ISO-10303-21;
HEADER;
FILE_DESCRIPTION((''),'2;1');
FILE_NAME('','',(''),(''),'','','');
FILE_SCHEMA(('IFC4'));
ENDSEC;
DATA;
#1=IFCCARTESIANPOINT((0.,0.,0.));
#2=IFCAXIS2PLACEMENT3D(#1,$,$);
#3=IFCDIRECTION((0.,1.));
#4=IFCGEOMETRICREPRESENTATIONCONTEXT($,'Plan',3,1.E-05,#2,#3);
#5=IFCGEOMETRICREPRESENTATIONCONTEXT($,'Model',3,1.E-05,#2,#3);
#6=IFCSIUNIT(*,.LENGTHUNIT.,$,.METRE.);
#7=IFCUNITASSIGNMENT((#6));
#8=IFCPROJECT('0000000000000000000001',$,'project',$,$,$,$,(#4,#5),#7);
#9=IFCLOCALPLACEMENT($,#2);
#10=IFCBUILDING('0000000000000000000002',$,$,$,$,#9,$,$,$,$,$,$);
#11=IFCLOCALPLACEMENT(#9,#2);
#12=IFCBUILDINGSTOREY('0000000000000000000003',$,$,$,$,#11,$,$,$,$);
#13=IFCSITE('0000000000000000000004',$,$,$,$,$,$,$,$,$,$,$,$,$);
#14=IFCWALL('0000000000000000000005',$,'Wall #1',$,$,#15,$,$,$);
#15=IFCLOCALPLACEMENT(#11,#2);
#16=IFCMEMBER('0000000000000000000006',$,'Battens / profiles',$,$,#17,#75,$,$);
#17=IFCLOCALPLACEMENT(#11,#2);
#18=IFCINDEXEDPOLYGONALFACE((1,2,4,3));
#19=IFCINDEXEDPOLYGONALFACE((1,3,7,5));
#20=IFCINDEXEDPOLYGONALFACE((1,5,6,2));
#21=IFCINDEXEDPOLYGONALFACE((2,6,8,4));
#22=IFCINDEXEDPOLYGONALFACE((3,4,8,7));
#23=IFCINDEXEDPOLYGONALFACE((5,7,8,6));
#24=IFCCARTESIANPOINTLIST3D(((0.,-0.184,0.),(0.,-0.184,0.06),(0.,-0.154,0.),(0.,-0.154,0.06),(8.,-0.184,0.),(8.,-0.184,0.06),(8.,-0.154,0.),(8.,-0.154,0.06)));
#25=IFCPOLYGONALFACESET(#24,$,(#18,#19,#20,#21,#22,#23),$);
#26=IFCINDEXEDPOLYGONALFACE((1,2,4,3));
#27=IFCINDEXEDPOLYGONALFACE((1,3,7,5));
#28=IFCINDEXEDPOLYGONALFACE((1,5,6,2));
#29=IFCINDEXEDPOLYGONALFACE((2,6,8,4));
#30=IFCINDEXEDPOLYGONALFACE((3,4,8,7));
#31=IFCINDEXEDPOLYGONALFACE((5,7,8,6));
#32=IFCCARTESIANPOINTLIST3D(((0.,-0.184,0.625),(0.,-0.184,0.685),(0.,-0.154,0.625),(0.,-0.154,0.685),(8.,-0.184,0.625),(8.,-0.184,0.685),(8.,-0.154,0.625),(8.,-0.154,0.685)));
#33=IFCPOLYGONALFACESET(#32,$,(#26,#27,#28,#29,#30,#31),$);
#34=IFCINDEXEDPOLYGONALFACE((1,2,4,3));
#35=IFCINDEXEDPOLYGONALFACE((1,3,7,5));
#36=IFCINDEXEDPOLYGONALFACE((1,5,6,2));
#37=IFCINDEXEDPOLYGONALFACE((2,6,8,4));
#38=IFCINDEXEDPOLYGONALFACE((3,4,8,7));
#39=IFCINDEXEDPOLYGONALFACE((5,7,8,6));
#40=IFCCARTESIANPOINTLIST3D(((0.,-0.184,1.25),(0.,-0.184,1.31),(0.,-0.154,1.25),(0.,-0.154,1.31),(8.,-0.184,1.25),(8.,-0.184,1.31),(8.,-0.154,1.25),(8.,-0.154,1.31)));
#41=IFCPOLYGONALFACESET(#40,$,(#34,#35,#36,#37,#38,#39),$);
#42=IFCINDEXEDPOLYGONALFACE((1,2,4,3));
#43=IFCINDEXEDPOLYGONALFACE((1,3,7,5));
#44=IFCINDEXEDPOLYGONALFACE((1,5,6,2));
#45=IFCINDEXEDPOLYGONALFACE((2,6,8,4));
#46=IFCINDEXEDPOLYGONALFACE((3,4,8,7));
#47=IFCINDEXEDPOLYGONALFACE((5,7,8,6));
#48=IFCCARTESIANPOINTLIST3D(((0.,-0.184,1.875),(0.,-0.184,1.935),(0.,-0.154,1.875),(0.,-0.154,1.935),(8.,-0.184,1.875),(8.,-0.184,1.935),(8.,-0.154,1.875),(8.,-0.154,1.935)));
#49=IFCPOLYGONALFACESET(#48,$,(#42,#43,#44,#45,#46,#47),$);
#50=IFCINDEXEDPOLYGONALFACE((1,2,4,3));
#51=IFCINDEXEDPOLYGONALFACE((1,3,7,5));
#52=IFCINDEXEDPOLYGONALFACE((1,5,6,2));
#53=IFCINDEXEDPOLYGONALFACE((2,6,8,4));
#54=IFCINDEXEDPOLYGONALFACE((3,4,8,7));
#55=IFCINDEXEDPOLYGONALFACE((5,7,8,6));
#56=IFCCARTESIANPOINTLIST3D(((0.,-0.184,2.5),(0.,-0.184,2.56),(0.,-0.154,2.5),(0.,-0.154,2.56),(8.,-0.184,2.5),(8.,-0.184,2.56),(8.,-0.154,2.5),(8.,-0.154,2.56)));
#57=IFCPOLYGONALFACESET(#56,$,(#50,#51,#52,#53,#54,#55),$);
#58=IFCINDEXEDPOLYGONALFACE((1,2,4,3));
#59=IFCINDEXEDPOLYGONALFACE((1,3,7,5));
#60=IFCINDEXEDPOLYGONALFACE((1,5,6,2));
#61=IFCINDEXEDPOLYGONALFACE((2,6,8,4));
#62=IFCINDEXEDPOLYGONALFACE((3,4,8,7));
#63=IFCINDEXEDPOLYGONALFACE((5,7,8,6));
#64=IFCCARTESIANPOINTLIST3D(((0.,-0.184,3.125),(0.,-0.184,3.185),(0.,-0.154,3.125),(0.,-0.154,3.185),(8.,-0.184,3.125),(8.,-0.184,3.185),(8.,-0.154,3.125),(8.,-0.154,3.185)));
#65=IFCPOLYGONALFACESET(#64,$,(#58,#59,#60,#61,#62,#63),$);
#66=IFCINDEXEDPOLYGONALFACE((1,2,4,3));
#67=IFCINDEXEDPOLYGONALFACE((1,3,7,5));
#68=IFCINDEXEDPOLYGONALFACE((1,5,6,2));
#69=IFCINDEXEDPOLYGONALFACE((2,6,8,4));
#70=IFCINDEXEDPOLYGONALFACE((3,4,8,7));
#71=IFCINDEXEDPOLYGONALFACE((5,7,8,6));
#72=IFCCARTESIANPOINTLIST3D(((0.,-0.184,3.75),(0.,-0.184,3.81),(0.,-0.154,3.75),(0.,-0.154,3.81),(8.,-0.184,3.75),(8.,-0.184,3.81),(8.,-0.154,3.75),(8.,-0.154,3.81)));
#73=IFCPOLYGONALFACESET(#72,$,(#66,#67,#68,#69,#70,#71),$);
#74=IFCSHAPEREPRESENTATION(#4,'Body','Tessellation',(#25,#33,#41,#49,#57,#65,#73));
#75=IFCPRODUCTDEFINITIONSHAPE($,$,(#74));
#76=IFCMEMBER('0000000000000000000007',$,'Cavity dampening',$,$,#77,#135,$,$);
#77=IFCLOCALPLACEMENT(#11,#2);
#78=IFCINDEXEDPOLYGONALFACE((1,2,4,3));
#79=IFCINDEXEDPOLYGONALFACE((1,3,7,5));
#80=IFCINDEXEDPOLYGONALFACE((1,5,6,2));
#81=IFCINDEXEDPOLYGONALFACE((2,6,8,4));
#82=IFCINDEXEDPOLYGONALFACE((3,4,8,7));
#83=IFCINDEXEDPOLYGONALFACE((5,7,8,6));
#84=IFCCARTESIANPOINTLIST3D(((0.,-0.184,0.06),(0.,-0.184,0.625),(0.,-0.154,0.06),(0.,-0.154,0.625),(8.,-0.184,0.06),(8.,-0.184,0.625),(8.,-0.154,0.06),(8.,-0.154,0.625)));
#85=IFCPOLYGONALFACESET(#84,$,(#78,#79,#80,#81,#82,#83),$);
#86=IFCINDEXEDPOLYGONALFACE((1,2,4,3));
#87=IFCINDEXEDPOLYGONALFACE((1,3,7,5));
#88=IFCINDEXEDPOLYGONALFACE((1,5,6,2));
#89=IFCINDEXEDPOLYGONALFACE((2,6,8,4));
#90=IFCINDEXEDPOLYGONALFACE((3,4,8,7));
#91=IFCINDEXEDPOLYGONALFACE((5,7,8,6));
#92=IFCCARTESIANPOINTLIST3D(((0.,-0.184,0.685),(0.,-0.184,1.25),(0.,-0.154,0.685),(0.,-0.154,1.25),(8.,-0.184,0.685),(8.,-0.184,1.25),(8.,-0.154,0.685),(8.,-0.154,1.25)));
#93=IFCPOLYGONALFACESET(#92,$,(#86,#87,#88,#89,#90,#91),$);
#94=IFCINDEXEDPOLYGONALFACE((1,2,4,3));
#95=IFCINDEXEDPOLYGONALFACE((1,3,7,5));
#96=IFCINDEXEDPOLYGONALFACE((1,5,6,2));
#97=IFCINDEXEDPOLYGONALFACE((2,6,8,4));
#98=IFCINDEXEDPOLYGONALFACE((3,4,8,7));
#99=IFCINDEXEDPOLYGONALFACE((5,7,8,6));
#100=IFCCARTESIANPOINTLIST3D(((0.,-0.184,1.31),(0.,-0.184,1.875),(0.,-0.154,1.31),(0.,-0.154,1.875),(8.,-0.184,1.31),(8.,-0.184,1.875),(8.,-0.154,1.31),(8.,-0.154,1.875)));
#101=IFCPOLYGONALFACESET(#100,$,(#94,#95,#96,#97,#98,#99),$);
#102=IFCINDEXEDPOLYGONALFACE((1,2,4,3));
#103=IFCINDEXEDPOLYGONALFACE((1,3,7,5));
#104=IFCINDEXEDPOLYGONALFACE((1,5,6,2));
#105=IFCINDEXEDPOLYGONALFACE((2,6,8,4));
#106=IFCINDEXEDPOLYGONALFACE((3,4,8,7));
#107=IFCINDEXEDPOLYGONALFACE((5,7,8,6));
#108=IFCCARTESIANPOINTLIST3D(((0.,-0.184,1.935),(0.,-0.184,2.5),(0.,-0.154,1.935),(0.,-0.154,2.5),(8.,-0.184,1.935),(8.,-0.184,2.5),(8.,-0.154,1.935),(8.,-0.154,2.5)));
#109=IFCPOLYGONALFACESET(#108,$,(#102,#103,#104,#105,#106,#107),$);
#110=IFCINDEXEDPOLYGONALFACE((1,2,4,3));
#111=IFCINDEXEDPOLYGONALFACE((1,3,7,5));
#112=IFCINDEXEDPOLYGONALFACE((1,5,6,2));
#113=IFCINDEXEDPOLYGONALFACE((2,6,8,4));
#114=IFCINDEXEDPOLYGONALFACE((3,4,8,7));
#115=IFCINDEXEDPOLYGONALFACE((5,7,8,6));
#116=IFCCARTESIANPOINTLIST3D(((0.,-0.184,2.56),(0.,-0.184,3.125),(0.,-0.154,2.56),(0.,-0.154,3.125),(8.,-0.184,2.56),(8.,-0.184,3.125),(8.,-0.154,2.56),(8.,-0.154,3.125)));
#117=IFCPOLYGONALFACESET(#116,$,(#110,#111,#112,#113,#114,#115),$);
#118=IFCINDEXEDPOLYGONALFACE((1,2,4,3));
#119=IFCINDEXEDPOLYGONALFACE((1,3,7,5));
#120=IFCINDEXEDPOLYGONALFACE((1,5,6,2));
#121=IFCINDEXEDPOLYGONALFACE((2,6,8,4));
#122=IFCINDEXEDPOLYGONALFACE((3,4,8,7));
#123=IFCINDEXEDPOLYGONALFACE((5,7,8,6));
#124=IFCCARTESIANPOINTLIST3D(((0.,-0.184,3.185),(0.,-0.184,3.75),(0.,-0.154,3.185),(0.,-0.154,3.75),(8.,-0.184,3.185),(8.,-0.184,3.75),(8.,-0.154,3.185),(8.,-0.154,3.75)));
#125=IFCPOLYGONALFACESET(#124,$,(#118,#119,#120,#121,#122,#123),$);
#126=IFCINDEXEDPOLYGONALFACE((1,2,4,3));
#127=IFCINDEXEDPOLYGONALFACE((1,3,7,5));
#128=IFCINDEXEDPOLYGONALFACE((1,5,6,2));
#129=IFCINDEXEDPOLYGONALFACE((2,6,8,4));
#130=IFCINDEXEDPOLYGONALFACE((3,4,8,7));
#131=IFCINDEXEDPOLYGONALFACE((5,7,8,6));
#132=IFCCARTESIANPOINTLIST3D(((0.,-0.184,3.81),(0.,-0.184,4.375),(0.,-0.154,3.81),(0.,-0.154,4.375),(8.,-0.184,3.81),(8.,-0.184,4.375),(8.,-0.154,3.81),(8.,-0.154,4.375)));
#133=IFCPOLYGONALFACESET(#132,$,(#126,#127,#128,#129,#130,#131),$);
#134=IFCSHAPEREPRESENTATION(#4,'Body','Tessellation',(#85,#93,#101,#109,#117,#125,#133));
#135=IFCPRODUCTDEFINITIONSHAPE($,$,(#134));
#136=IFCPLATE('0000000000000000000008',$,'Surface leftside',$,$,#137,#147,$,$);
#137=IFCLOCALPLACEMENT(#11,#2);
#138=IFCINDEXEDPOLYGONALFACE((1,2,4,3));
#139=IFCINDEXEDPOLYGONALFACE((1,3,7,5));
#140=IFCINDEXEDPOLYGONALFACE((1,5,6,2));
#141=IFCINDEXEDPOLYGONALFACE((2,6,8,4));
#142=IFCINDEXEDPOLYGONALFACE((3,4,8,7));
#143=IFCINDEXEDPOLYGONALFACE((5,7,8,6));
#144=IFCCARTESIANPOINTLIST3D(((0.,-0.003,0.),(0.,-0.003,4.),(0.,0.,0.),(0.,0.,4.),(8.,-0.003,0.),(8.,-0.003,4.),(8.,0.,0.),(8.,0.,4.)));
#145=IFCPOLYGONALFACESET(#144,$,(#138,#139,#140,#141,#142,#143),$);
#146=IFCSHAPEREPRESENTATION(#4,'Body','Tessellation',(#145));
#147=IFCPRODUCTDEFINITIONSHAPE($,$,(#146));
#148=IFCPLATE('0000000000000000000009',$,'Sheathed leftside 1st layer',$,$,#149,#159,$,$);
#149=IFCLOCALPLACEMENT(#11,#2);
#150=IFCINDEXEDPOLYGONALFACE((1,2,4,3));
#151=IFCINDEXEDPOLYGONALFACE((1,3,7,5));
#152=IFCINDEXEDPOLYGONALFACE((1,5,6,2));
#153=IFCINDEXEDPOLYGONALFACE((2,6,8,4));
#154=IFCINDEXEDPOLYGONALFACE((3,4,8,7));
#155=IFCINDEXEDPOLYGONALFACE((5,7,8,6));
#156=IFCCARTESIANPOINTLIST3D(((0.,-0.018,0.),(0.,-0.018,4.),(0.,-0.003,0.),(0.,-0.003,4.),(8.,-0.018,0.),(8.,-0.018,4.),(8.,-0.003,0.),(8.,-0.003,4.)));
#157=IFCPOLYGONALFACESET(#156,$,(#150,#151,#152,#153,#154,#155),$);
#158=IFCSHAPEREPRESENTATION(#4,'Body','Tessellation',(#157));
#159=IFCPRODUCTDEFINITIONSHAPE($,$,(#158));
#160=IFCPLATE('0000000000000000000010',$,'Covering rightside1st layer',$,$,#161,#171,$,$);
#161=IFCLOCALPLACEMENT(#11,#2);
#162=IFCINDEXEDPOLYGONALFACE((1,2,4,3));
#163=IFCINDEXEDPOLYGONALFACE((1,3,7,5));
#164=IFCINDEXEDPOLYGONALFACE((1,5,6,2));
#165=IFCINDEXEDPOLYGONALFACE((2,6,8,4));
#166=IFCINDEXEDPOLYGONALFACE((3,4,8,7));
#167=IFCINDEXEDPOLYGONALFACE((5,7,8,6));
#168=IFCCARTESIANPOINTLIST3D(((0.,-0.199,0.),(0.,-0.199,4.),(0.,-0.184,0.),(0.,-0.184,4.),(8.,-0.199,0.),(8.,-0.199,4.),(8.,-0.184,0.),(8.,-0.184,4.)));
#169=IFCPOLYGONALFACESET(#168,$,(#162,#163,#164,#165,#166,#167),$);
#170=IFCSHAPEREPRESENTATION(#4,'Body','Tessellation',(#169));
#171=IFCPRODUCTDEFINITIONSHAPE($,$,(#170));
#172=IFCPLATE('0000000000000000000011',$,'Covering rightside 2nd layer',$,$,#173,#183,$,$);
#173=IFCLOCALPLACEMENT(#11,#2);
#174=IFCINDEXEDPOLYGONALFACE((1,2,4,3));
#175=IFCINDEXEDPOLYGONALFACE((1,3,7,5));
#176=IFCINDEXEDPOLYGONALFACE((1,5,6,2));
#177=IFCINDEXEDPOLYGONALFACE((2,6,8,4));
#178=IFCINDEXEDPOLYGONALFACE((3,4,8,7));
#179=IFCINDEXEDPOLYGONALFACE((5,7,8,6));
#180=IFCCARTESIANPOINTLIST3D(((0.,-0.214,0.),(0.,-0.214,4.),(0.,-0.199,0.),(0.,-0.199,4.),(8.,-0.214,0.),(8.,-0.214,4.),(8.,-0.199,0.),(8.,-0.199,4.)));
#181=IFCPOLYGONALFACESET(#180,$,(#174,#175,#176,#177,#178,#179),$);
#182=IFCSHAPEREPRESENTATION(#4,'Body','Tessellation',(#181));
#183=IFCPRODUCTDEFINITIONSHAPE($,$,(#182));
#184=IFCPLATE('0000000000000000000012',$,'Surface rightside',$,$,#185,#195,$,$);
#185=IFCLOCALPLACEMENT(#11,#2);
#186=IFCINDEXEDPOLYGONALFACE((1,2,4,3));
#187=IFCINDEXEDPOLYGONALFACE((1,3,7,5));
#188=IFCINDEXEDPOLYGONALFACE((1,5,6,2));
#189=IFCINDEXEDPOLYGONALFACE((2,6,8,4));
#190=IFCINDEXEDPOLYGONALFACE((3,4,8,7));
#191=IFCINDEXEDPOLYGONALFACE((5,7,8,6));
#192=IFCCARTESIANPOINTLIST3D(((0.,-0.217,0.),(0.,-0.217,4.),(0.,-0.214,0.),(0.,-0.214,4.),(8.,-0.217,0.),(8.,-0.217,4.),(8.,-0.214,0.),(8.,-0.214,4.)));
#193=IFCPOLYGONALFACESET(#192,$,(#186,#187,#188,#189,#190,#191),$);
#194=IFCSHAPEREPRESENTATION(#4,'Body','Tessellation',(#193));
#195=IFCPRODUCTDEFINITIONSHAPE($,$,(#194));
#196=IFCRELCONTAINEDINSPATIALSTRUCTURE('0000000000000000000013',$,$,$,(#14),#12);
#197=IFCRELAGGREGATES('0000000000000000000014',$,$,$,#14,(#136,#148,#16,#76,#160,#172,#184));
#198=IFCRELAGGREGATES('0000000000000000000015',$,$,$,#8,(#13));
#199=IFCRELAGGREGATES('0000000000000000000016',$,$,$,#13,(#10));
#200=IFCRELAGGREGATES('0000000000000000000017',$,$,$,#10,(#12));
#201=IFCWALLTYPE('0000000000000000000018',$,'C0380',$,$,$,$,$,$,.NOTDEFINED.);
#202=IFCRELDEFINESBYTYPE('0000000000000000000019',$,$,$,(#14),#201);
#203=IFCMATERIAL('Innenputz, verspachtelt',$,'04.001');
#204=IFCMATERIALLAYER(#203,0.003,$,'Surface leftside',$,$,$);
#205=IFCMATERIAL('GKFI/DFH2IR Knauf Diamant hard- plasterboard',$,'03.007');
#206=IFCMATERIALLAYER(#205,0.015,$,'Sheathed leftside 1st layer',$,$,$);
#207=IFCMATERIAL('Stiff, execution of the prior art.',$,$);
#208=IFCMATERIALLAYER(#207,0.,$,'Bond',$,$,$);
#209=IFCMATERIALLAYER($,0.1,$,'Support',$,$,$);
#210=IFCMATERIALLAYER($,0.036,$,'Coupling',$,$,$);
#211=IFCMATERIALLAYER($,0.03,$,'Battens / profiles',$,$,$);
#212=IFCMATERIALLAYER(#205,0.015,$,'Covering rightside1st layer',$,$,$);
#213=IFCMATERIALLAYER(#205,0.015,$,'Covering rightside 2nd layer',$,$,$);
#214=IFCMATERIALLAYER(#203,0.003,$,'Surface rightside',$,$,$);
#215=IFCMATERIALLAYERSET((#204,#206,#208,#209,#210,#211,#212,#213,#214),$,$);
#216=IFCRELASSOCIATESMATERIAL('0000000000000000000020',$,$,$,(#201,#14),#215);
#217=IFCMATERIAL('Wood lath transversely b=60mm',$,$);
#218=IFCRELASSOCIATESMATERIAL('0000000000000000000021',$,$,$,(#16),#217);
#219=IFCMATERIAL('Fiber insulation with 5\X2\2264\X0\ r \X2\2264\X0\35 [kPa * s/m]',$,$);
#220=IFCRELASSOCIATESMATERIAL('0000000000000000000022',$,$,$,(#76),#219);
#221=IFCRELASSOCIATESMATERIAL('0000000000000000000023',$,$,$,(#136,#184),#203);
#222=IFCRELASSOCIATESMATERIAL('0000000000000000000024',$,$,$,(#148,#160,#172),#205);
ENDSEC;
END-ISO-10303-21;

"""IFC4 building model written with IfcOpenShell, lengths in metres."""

from ifc_helpers import new_model, si_unit, direction, frame, frame_2d, origin, origin_with_axes, place, context, project, spatial, rectangle, extrude, material, layer, layer_set, type_object, element, aggregate, save


model = new_model("IFC4")

# Units and contexts
plan_context = context("Plan", 3, precision=1e-05, world=origin(), true_north=direction((0.0, 1.0)))
model_context = context("Model", 3, precision=1e-05, world=origin(), true_north=direction((0.0, 1.0)))
ifc_project = project(units=[si_unit("LENGTHUNIT", "METRE")], contexts=[plan_context, model_context])

# Site, building, storey
site = spatial("IfcSite", under=ifc_project)
building_placement = place(None, origin())
building = spatial("IfcBuilding", under=site, at=building_placement)
storey_placement = place(building_placement, origin())
storey = spatial("IfcBuildingStorey", under=building, at=storey_placement)

# Wall, members, plates
ifc_material_1 = material(Name="Innenputz, verspachtelt", Category="04.001")
ifc_layer_1 = layer(ifc_material_1, 0.003, Name="Surface leftside")
ifc_material_2 = material(Name="GKFI/DFH2IR Knauf Diamant hard- plasterboard", Category="03.007")
ifc_layer_2 = layer(ifc_material_2, 0.015, Name="Sheathed leftside 1st layer")
ifc_material_3 = material(Name="Stiff, execution of the prior art.")
ifc_layer_3 = layer(ifc_material_3, 0.0, Name="Bond")
ifc_layer_4 = layer(None, 0.1, Name="Support")
ifc_layer_5 = layer(None, 0.036, Name="Coupling")
ifc_layer_6 = layer(None, 0.03, Name="Battens / profiles")
ifc_layer_7 = layer(ifc_material_2, 0.015, Name="Covering rightside1st layer")
ifc_layer_8 = layer(ifc_material_2, 0.015, Name="Covering rightside 2nd layer")
ifc_layer_9 = layer(ifc_material_1, 0.003, Name="Surface rightside")
ifc_layer_set = layer_set([ifc_layer_1, ifc_layer_2, ifc_layer_3, ifc_layer_4, ifc_layer_5, ifc_layer_6, ifc_layer_7, ifc_layer_8, ifc_layer_9])
wall_type = type_object("IfcWallType", Name="C0380", PredefinedType="NOTDEFINED", material=ifc_layer_set)
wall_placement = place(None, frame((0.0, 0.0, 0.0), z_axis=(0.0, -1.0, 0.0), x_axis=(1.0, 0.0, 0.0)))
wall = element("IfcWall", 1, at=wall_placement, inside=storey, type_object=wall_type, material=ifc_layer_set, Name="Wall #1")
ifc_material_4 = material(Name="Wood lath transversely b=60mm")
member_1_placement = place(wall_placement, origin())
member_1 = element("IfcMember", 2, at=member_1_placement, material=ifc_material_4, Name="Battens / profiles", context=plan_context, shape_type="SweptSolid", body=[
    extrude(rectangle(XDim=0.06, YDim=0.03, at=frame_2d((0.03, 0.015), x_axis=(1.0, 0.0))), frame((0.0, 0.0, 0.154), z_axis=(1.0, 0.0, 0.0), x_axis=(0.0, 1.0, 0.0)), (0.0, 0.0, 1.0), 8.0),
    extrude(rectangle(XDim=0.06, YDim=0.03, at=frame_2d((0.03, 0.015), x_axis=(1.0, 0.0))), frame((0.0, 0.625, 0.154), z_axis=(1.0, 0.0, 0.0), x_axis=(0.0, 1.0, 0.0)), (0.0, 0.0, 1.0), 8.0),
    extrude(rectangle(XDim=0.06, YDim=0.03, at=frame_2d((0.03, 0.015), x_axis=(1.0, 0.0))), frame((0.0, 1.25, 0.154), z_axis=(1.0, 0.0, 0.0), x_axis=(0.0, 1.0, 0.0)), (0.0, 0.0, 1.0), 8.0),
    extrude(rectangle(XDim=0.06, YDim=0.03, at=frame_2d((0.03, 0.015), x_axis=(1.0, 0.0))), frame((0.0, 1.875, 0.154), z_axis=(1.0, 0.0, 0.0), x_axis=(0.0, 1.0, 0.0)), (0.0, 0.0, 1.0), 8.0),
    extrude(rectangle(XDim=0.06, YDim=0.03, at=frame_2d((0.03, 0.015), x_axis=(1.0, 0.0))), frame((0.0, 2.5, 0.154), z_axis=(1.0, 0.0, 0.0), x_axis=(0.0, 1.0, 0.0)), (0.0, 0.0, 1.0), 8.0),
    extrude(rectangle(XDim=0.06, YDim=0.03, at=frame_2d((0.03, 0.015), x_axis=(1.0, 0.0))), frame((0.0, 3.125, 0.154), z_axis=(1.0, 0.0, 0.0), x_axis=(0.0, 1.0, 0.0)), (0.0, 0.0, 1.0), 8.0),
    extrude(rectangle(XDim=0.06, YDim=0.03, at=frame_2d((0.03, 0.015), x_axis=(1.0, 0.0))), frame((0.0, 3.75, 0.154), z_axis=(1.0, 0.0, 0.0), x_axis=(0.0, 1.0, 0.0)), (0.0, 0.0, 1.0), 8.0),
])
ifc_material_5 = material(Name="Fiber insulation with 5≤ r ≤35 [kPa * s/m]")
member_2_placement = place(wall_placement, origin())
member_2 = element("IfcMember", 3, at=member_2_placement, material=ifc_material_5, Name="Cavity dampening", context=plan_context, shape_type="SweptSolid", body=[
    extrude(rectangle(XDim=0.565, YDim=0.03, at=frame_2d((0.2825, 0.015), x_axis=(1.0, 0.0))), frame((0.0, 0.06, 0.154), z_axis=(1.0, 0.0, 0.0), x_axis=(0.0, 1.0, 0.0)), (0.0, 0.0, 1.0), 8.0),
    extrude(rectangle(XDim=0.565, YDim=0.03, at=frame_2d((0.2825, 0.015), x_axis=(1.0, 0.0))), frame((0.0, 0.685, 0.154), z_axis=(1.0, 0.0, 0.0), x_axis=(0.0, 1.0, 0.0)), (0.0, 0.0, 1.0), 8.0),
    extrude(rectangle(XDim=0.565, YDim=0.03, at=frame_2d((0.2825, 0.015), x_axis=(1.0, 0.0))), frame((0.0, 1.31, 0.154), z_axis=(1.0, 0.0, 0.0), x_axis=(0.0, 1.0, 0.0)), (0.0, 0.0, 1.0), 8.0),
    extrude(rectangle(XDim=0.565, YDim=0.03, at=frame_2d((0.2825, 0.015), x_axis=(1.0, 0.0))), frame((0.0, 1.935, 0.154), z_axis=(1.0, 0.0, 0.0), x_axis=(0.0, 1.0, 0.0)), (0.0, 0.0, 1.0), 8.0),
    extrude(rectangle(XDim=0.565, YDim=0.03, at=frame_2d((0.2825, 0.015), x_axis=(1.0, 0.0))), frame((0.0, 2.56, 0.154), z_axis=(1.0, 0.0, 0.0), x_axis=(0.0, 1.0, 0.0)), (0.0, 0.0, 1.0), 8.0),
    extrude(rectangle(XDim=0.565, YDim=0.03, at=frame_2d((0.2825, 0.015), x_axis=(1.0, 0.0))), frame((0.0, 3.185, 0.154), z_axis=(1.0, 0.0, 0.0), x_axis=(0.0, 1.0, 0.0)), (0.0, 0.0, 1.0), 8.0),
    extrude(rectangle(XDim=0.565, YDim=0.03, at=frame_2d((0.2825, 0.015), x_axis=(1.0, 0.0))), frame((0.0, 3.81, 0.154), z_axis=(1.0, 0.0, 0.0), x_axis=(0.0, 1.0, 0.0)), (0.0, 0.0, 1.0), 8.0),
])
plate_1_placement = place(wall_placement, origin())
plate_1 = element("IfcPlate", 4, at=plate_1_placement, material=ifc_material_1, Name="Surface leftside", context=plan_context, shape_type="SweptSolid", body=[
    extrude(rectangle(XDim=8.0, YDim=4.0, at=frame_2d((4.0, 2.0), x_axis=(1.0, 0.0))), origin_with_axes(), (0.0, 0.0, 1.0), 0.003),
])
plate_2_placement = place(wall_placement, origin())
plate_2 = element("IfcPlate", 5, at=plate_2_placement, material=ifc_material_2, Name="Sheathed leftside 1st layer", context=plan_context, shape_type="SweptSolid", body=[
    extrude(rectangle(XDim=8.0, YDim=4.0, at=frame_2d((4.0, 2.0), x_axis=(1.0, 0.0))), frame((0.0, 0.0, 0.003), z_axis=(0.0, 0.0, 1.0), x_axis=(1.0, 0.0, 0.0)), (0.0, 0.0, 1.0), 0.015),
])
plate_3_placement = place(wall_placement, origin())
plate_3 = element("IfcPlate", 6, at=plate_3_placement, material=ifc_material_2, Name="Covering rightside1st layer", context=plan_context, shape_type="SweptSolid", body=[
    extrude(rectangle(XDim=8.0, YDim=4.0, at=frame_2d((4.0, 2.0), x_axis=(1.0, 0.0))), frame((0.0, 0.0, 0.184), z_axis=(0.0, 0.0, 1.0), x_axis=(1.0, 0.0, 0.0)), (0.0, 0.0, 1.0), 0.015),
])
plate_4_placement = place(wall_placement, origin())
plate_4 = element("IfcPlate", 7, at=plate_4_placement, material=ifc_material_2, Name="Covering rightside 2nd layer", context=plan_context, shape_type="SweptSolid", body=[
    extrude(rectangle(XDim=8.0, YDim=4.0, at=frame_2d((4.0, 2.0), x_axis=(1.0, 0.0))), frame((0.0, 0.0, 0.199), z_axis=(0.0, 0.0, 1.0), x_axis=(1.0, 0.0, 0.0)), (0.0, 0.0, 1.0), 0.015),
])
plate_5_placement = place(wall_placement, origin())
plate_5 = element("IfcPlate", 8, at=plate_5_placement, material=ifc_material_1, Name="Surface rightside", context=plan_context, shape_type="SweptSolid", body=[
    extrude(rectangle(XDim=8.0, YDim=4.0, at=frame_2d((4.0, 2.0), x_axis=(1.0, 0.0))), frame((0.0, 0.0, 0.214), z_axis=(0.0, 0.0, 1.0), x_axis=(1.0, 0.0, 0.0)), (0.0, 0.0, 1.0), 0.003),
])
aggregate(wall, [plate_1, plate_2, member_1, member_2, plate_3, plate_4, plate_5])

save(model, "model.ifc")
